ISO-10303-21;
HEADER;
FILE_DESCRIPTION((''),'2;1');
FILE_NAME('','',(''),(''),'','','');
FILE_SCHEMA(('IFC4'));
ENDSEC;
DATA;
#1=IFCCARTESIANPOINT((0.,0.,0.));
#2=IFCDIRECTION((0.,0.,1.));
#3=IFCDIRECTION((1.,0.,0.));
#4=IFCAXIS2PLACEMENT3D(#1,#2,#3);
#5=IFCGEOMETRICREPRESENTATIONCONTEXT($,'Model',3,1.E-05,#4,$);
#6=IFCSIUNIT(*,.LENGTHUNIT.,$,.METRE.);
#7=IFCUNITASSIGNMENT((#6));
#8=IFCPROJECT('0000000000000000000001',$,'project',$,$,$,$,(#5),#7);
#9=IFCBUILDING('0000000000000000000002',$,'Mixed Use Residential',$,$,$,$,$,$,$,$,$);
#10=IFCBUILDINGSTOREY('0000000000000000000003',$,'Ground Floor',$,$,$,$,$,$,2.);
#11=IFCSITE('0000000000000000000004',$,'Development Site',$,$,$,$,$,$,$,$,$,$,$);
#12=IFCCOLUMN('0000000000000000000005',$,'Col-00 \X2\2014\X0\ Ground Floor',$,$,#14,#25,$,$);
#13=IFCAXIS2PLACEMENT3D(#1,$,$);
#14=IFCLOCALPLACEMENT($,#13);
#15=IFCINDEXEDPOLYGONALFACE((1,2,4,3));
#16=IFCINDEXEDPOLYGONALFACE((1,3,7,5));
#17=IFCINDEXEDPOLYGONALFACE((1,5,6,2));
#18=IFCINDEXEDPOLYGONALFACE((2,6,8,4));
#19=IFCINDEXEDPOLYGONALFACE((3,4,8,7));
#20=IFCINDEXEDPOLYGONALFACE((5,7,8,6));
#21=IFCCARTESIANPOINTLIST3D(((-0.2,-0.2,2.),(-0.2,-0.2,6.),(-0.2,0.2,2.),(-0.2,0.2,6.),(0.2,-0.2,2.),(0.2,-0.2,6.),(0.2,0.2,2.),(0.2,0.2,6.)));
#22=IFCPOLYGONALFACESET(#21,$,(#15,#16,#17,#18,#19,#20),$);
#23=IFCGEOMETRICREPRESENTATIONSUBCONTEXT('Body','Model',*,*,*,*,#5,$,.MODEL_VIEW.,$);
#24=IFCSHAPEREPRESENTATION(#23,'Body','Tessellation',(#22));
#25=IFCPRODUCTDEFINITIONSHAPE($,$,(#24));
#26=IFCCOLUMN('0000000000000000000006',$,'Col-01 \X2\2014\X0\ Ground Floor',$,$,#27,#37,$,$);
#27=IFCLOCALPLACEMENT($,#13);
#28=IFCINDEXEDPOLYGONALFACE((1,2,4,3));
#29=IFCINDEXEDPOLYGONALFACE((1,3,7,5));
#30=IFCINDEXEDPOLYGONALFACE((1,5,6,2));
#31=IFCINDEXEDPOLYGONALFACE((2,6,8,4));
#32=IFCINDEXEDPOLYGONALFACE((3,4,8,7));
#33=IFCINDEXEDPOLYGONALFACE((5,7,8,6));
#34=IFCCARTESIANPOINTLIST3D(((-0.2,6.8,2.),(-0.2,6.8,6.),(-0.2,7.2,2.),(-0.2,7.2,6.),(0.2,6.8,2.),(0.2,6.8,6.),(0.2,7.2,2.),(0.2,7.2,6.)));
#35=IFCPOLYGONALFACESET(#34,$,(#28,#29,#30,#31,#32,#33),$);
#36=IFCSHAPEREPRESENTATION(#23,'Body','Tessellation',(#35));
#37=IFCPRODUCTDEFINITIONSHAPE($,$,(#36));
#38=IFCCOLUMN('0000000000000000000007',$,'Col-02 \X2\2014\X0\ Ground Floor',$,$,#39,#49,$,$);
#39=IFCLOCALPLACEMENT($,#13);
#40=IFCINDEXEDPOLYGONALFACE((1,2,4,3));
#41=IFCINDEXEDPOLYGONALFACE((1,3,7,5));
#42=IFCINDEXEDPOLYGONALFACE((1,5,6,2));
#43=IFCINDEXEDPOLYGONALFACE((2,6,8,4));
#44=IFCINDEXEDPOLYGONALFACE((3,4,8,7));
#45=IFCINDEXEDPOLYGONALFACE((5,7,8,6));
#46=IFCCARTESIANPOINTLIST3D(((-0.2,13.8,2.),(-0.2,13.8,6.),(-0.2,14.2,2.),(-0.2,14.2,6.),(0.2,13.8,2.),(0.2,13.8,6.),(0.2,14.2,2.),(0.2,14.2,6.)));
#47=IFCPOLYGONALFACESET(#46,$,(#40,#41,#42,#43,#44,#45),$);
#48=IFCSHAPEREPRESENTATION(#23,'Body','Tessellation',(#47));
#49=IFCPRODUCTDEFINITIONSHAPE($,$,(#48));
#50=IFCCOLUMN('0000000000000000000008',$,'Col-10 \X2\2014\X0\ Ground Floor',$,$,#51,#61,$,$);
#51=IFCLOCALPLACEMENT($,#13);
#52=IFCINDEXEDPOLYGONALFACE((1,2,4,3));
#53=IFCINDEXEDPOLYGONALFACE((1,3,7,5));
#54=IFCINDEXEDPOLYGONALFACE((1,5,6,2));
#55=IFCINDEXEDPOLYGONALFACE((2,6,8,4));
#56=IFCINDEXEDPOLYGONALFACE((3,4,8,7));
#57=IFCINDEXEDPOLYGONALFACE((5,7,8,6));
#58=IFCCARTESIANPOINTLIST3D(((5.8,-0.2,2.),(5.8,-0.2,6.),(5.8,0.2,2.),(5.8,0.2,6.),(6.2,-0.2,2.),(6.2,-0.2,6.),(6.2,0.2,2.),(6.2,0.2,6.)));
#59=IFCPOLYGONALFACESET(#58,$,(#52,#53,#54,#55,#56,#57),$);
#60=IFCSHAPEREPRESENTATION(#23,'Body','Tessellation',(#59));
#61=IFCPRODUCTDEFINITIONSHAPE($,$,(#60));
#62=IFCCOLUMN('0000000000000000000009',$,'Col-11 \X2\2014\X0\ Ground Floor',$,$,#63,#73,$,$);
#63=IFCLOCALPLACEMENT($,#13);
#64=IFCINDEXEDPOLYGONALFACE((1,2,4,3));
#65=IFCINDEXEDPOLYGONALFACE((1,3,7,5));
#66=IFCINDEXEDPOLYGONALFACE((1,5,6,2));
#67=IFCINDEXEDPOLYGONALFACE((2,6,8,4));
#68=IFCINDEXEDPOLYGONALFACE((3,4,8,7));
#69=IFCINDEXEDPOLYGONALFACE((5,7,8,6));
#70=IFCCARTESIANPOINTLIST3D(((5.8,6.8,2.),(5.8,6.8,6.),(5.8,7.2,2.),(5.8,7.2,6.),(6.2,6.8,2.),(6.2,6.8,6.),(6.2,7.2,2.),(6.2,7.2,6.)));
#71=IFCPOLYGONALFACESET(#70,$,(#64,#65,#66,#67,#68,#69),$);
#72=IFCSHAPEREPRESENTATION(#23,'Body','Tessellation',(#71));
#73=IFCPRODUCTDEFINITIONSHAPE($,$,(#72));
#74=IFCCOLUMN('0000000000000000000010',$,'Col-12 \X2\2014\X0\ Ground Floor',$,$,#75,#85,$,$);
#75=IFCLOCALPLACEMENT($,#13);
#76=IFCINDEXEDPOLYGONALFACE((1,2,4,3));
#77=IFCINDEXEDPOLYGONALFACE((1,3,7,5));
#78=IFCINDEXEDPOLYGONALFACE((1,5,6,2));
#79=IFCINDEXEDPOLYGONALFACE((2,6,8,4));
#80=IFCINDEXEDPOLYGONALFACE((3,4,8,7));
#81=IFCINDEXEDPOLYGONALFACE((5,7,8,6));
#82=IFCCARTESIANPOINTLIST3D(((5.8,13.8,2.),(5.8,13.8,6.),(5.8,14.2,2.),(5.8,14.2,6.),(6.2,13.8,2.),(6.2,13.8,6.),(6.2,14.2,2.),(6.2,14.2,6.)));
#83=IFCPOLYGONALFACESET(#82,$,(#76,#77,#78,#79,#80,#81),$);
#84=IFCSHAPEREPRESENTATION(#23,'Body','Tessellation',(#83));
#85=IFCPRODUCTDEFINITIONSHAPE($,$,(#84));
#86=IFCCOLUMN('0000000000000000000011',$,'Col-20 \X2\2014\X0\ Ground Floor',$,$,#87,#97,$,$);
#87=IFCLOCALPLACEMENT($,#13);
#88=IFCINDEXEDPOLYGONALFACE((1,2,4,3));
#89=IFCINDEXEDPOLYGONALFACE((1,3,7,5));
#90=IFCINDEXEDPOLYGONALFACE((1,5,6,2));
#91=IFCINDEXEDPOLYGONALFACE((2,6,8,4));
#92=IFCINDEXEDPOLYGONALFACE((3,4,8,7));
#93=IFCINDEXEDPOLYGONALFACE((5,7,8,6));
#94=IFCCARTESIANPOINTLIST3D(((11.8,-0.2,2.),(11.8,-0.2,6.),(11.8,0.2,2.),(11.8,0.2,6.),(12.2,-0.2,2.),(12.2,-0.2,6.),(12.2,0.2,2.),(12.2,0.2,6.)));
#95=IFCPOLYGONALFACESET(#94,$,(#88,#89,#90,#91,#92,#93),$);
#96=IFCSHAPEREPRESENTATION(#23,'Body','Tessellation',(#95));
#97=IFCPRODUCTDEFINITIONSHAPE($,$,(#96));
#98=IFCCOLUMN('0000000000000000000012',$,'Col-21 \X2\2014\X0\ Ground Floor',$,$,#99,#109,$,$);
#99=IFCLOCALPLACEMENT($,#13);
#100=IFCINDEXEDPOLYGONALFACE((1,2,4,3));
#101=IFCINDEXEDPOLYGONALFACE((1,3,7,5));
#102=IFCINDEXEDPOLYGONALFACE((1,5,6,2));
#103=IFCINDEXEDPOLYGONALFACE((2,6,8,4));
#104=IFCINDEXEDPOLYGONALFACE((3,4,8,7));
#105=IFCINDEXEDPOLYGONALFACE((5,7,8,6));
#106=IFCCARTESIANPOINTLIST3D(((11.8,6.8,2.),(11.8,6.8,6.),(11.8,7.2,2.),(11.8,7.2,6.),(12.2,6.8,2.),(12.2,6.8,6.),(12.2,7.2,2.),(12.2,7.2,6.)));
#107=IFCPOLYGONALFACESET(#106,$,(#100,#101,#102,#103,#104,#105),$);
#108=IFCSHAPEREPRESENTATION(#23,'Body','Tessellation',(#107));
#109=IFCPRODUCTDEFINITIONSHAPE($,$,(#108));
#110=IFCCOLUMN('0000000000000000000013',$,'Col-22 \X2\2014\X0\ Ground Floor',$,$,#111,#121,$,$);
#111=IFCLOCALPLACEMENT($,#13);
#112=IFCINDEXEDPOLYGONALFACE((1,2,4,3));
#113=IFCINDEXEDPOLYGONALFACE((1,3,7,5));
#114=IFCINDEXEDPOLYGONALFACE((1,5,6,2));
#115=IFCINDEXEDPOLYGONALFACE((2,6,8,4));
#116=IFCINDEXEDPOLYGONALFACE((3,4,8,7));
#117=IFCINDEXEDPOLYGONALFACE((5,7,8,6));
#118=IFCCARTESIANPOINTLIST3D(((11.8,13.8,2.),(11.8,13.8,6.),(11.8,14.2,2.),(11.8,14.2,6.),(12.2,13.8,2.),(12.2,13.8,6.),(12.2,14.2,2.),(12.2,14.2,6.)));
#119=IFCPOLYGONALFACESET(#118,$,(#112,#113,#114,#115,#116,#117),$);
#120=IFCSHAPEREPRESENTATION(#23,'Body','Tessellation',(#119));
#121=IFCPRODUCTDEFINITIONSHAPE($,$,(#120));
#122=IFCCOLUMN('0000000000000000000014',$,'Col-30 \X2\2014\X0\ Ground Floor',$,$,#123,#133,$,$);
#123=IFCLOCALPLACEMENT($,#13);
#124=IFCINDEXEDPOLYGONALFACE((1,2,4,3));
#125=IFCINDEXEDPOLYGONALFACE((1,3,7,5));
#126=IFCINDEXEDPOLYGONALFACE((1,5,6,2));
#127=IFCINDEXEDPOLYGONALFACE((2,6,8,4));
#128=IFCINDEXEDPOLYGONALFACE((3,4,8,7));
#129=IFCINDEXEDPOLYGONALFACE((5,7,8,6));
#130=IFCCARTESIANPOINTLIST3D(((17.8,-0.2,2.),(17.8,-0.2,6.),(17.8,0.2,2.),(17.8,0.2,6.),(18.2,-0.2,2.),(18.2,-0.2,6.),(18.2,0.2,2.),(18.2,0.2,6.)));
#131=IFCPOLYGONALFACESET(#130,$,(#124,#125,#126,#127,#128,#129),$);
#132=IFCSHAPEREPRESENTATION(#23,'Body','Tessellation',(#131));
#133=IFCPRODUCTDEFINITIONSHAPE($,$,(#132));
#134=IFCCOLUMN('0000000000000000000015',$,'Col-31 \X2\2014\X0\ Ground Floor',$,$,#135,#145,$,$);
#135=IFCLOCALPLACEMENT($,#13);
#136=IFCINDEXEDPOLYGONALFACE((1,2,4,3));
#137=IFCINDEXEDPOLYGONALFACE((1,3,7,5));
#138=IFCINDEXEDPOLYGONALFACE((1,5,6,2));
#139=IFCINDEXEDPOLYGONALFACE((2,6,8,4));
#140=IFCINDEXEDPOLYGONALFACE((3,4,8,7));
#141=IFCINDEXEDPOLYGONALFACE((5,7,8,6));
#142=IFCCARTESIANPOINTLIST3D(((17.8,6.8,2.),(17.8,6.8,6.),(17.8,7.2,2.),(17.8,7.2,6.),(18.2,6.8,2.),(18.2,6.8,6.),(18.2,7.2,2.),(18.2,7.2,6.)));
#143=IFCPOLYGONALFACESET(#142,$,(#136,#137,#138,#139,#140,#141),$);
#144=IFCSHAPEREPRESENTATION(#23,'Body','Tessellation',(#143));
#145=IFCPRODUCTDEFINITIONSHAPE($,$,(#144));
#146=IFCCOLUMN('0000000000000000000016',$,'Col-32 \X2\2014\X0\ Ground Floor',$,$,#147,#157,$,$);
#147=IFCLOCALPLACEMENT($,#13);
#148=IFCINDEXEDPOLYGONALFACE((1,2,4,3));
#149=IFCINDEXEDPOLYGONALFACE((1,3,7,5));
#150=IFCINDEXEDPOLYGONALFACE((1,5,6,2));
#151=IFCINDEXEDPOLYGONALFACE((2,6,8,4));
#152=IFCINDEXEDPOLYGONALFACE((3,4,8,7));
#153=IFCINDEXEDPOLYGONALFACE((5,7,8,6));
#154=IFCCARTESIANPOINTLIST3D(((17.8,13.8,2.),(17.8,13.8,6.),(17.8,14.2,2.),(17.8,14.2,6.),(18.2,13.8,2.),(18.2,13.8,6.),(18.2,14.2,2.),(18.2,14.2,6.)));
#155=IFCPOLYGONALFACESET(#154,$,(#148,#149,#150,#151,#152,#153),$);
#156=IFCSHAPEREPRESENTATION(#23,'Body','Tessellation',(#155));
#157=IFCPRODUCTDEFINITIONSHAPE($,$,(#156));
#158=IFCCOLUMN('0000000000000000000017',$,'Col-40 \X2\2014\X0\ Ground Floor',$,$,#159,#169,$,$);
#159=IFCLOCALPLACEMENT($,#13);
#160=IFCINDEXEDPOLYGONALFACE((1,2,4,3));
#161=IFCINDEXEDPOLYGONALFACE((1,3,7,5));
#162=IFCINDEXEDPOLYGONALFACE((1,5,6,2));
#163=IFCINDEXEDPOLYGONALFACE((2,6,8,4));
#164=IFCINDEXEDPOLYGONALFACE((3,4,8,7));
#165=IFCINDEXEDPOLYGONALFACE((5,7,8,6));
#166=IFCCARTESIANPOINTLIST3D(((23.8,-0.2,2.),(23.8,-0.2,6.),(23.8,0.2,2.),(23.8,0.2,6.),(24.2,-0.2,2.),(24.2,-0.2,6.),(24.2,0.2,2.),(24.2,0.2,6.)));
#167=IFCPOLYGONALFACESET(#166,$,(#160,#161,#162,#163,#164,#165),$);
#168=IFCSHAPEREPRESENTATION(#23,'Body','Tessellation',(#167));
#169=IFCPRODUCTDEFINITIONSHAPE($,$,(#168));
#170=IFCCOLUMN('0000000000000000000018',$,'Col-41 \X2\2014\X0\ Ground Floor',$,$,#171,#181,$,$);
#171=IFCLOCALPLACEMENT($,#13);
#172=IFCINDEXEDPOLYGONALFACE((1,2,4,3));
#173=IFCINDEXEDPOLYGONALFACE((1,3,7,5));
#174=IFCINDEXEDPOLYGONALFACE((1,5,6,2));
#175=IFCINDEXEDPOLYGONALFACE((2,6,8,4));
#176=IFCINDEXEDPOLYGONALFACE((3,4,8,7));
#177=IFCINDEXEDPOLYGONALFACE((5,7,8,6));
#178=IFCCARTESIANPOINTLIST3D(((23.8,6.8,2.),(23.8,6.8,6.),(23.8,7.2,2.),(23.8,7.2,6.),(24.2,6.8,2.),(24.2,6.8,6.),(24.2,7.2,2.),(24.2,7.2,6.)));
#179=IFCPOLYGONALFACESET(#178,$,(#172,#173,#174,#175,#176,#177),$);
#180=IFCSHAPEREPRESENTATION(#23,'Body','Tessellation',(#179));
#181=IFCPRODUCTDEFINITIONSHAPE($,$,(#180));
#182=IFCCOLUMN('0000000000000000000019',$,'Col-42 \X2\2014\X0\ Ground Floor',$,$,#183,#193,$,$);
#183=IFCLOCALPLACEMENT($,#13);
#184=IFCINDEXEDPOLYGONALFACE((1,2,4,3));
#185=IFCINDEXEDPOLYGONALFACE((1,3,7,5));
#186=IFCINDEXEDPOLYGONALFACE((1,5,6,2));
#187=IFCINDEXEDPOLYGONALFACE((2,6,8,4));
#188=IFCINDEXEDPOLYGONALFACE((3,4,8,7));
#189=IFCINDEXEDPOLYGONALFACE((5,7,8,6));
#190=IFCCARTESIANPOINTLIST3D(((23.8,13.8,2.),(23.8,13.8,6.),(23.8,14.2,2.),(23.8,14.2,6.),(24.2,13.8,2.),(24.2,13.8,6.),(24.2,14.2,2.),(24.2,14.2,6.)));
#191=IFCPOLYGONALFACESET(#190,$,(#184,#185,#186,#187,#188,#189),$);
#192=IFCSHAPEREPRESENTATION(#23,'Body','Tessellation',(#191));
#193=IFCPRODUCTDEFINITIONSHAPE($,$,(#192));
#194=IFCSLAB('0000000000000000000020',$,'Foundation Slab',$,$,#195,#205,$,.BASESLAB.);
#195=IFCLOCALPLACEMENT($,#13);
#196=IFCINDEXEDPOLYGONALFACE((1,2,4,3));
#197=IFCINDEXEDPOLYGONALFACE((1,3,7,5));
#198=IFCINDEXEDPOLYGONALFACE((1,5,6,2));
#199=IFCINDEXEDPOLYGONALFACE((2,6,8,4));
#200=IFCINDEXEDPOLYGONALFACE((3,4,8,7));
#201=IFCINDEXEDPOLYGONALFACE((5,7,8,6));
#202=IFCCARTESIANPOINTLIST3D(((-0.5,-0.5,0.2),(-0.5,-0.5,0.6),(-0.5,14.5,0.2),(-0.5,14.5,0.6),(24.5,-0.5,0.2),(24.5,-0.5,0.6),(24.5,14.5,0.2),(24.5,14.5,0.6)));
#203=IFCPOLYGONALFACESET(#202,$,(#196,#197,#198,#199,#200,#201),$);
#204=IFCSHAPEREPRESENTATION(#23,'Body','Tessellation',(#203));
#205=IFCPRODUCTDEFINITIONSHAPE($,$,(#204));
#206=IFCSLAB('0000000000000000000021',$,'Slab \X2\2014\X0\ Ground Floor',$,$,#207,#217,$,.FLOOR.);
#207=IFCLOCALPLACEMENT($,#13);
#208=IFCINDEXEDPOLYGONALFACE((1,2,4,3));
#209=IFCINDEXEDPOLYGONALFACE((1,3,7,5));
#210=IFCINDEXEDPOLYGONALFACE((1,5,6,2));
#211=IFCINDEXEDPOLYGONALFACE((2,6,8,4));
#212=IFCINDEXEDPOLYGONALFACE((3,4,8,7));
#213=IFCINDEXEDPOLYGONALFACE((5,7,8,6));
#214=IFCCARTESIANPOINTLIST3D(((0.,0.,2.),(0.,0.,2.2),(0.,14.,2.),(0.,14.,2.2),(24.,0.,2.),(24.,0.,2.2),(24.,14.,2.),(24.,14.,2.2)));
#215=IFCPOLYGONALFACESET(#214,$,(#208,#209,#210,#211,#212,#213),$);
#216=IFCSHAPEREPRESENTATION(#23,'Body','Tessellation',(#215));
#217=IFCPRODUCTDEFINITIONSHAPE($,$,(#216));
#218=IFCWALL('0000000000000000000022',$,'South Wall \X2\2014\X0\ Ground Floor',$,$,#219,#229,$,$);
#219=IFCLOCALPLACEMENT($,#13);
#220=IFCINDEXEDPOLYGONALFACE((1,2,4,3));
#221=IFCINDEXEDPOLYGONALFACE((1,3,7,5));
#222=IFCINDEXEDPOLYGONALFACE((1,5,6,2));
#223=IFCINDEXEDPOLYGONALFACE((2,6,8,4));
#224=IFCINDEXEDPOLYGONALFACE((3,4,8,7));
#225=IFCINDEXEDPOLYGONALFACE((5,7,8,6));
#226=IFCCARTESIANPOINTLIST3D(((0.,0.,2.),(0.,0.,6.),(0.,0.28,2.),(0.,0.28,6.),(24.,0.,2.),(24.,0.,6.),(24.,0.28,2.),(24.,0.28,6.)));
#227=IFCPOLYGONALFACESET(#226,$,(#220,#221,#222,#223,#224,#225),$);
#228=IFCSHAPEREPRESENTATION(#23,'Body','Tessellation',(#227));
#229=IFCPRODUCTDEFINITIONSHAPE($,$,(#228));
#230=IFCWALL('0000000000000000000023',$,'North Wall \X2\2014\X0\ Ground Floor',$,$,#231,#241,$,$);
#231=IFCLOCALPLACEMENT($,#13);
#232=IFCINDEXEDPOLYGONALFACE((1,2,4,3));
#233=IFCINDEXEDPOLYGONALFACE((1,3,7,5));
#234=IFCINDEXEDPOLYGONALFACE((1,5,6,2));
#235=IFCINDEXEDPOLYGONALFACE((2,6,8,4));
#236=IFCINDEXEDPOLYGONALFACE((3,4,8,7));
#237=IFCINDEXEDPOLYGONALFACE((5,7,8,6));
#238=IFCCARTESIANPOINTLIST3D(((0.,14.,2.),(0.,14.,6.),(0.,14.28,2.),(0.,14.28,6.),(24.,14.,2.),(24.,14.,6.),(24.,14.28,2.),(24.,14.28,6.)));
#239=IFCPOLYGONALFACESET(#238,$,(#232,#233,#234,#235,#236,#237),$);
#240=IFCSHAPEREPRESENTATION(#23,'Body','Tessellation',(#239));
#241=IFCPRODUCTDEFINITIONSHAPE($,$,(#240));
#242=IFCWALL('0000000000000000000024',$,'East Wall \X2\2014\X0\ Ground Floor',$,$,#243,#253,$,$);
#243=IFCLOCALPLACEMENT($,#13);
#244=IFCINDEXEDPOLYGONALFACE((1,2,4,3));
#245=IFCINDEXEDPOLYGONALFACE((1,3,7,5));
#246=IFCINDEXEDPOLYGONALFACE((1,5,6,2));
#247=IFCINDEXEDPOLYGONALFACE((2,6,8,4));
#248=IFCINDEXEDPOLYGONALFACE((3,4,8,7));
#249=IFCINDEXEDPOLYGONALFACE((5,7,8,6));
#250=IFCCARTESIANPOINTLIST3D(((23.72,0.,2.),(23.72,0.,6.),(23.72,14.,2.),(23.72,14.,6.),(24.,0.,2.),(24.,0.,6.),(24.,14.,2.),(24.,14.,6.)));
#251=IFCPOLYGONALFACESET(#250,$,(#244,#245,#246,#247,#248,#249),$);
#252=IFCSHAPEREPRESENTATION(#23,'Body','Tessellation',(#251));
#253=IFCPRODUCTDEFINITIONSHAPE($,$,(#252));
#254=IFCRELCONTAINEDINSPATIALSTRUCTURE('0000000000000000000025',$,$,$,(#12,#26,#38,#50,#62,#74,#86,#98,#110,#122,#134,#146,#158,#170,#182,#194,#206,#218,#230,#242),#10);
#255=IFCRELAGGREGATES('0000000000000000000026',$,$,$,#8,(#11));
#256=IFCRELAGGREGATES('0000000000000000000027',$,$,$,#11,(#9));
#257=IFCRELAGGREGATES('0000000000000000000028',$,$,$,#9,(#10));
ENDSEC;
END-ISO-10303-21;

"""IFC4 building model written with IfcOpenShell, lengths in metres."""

from ifc_helpers import new_model, si_unit, frame, origin_with_axes, place, context, subcontext, project, spatial, indexed_curve, rectangle, outline, extrude, element, save


model = new_model("IFC4")

# Units and contexts
model_context = context("Model", 3, precision=1e-05, world=origin_with_axes())
body_context = subcontext(model_context, "Body", "Model", "MODEL_VIEW")
ifc_project = project(units=[si_unit("LENGTHUNIT", "METRE")], contexts=[model_context])

# Site, building, storey
site = spatial("IfcSite", under=ifc_project, Name="Development Site")
building = spatial("IfcBuilding", under=site, Name="Mixed Use Residential")
storey = spatial("IfcBuildingStorey", under=building, Name="Ground Floor", Elevation=2.0)

# Columns
for number, where, z_axis, x_axis, name in (
    (1, (0.0, 0.0, 2.0), (0.0, 0.0, 1.0), (1.0, 0.0, 0.0), "Col-00 — Ground Floor"),
    (2, (0.0, 7.0, 2.0), (0.0, 0.0, 1.0), (1.0, 0.0, 0.0), "Col-01 — Ground Floor"),
    (3, (0.0, 14.0, 2.0), (0.0, 0.0, 1.0), (1.0, 0.0, 0.0), "Col-02 — Ground Floor"),
    (4, (6.0, 0.0, 2.0), (0.0, 0.0, 1.0), (1.0, 0.0, 0.0), "Col-10 — Ground Floor"),
    (5, (6.0, 7.0, 2.0), (0.0, 0.0, 1.0), (1.0, 0.0, 0.0), "Col-11 — Ground Floor"),
    (6, (6.0, 14.0, 2.0), (0.0, 0.0, 1.0), (1.0, 0.0, 0.0), "Col-12 — Ground Floor"),
    (7, (12.0, 0.0, 2.0), (0.0, 0.0, 1.0), (1.0, 0.0, 0.0), "Col-20 — Ground Floor"),
    (8, (12.0, 7.0, 2.0), (0.0, 0.0, 1.0), (1.0, 0.0, 0.0), "Col-21 — Ground Floor"),
    (9, (12.0, 14.0, 2.0), (0.0, 0.0, 1.0), (1.0, 0.0, 0.0), "Col-22 — Ground Floor"),
    (10, (18.0, 0.0, 2.0), (0.0, 0.0, 1.0), (1.0, 0.0, 0.0), "Col-30 — Ground Floor"),
    (11, (18.0, 7.0, 2.0), (0.0, 0.0, 1.0), (1.0, 0.0, 0.0), "Col-31 — Ground Floor"),
    (12, (18.0, 14.0, 2.0), (0.0, 0.0, 1.0), (1.0, 0.0, 0.0), "Col-32 — Ground Floor"),
    (13, (24.0, 0.0, 2.0), (0.0, 0.0, 1.0), (1.0, 0.0, 0.0), "Col-40 — Ground Floor"),
    (14, (24.0, 7.0, 2.0), (0.0, 0.0, 1.0), (1.0, 0.0, 0.0), "Col-41 — Ground Floor"),
    (15, (24.0, 14.0, 2.0), (0.0, 0.0, 1.0), (1.0, 0.0, 0.0), "Col-42 — Ground Floor"),
):
    element("IfcColumn", number, at=place(None, frame(where, z_axis=z_axis, x_axis=x_axis)), inside=storey, Name=name, context=body_context, shape_type="SweptSolid", body=[
        extrude(rectangle(XDim=0.4, YDim=0.4), origin_with_axes(), (0.0, 0.0, 1.0), 4.0),
    ])

# Slabs
slab_1_placement = place(None, frame((0.0, 0.0, 0.2), z_axis=(0.0, 0.0, 1.0), x_axis=(1.0, 0.0, 0.0)))
element("IfcSlab", 16, at=slab_1_placement, inside=storey, Name="Foundation Slab", PredefinedType="BASESLAB", context=body_context, shape_type="SweptSolid", body=[
    extrude(outline(indexed_curve([(-0.5, -0.5), (24.5, -0.5), (24.5, 14.5), (-0.5, 14.5), (-0.5, -0.5)])), None, (0.0, 0.0, 1.0), 0.4),
])
slab_2_placement = place(None, frame((0.0, 0.0, 2.0), z_axis=(0.0, 0.0, 1.0), x_axis=(1.0, 0.0, 0.0)))
element("IfcSlab", 17, at=slab_2_placement, inside=storey, Name="Slab — Ground Floor", PredefinedType="FLOOR", context=body_context, shape_type="SweptSolid", body=[
    extrude(outline(indexed_curve([(0.0, 0.0), (24.0, 0.0), (24.0, 14.0), (0.0, 14.0), (0.0, 0.0)])), None, (0.0, 0.0, 1.0), 0.2),
])

# Walls
for number, where, z_axis, x_axis, name in (
    (18, (0.0, 0.0, 2.0), (0.0, 0.0, 1.0), (1.0, 0.0, 0.0), "South Wall — Ground Floor"),
    (19, (0.0, 14.0, 2.0), (0.0, 0.0, 1.0), (1.0, 0.0, 0.0), "North Wall — Ground Floor"),
):
    element("IfcWall", number, at=place(None, frame(where, z_axis=z_axis, x_axis=x_axis)), inside=storey, Name=name, context=body_context, shape_type="SweptSolid", body=[
        extrude(outline(indexed_curve([(0.0, 0.0), (0.0, 0.28), (24.0, 0.28), (24.0, 0.0), (0.0, 0.0)], self_intersect=False)), origin_with_axes(), (0.0, 0.0, 1.0), 4.0),
    ])
for number, where, z_axis, x_axis, name in (
    (20, (24.0, 0.0, 2.0), (0.0, 0.0, 1.0), (0.0, 1.0, 0.0), "East Wall — Ground Floor"),
):
    element("IfcWall", number, at=place(None, frame(where, z_axis=z_axis, x_axis=x_axis)), inside=storey, Name=name, context=body_context, shape_type="SweptSolid", body=[
        extrude(outline(indexed_curve([(0.0, 0.0), (0.0, 0.28), (14.0, 0.28), (14.0, 0.0), (0.0, 0.0)], self_intersect=False)), origin_with_axes(), (0.0, 0.0, 1.0), 4.0),
    ])

save(model, "model.ifc")
